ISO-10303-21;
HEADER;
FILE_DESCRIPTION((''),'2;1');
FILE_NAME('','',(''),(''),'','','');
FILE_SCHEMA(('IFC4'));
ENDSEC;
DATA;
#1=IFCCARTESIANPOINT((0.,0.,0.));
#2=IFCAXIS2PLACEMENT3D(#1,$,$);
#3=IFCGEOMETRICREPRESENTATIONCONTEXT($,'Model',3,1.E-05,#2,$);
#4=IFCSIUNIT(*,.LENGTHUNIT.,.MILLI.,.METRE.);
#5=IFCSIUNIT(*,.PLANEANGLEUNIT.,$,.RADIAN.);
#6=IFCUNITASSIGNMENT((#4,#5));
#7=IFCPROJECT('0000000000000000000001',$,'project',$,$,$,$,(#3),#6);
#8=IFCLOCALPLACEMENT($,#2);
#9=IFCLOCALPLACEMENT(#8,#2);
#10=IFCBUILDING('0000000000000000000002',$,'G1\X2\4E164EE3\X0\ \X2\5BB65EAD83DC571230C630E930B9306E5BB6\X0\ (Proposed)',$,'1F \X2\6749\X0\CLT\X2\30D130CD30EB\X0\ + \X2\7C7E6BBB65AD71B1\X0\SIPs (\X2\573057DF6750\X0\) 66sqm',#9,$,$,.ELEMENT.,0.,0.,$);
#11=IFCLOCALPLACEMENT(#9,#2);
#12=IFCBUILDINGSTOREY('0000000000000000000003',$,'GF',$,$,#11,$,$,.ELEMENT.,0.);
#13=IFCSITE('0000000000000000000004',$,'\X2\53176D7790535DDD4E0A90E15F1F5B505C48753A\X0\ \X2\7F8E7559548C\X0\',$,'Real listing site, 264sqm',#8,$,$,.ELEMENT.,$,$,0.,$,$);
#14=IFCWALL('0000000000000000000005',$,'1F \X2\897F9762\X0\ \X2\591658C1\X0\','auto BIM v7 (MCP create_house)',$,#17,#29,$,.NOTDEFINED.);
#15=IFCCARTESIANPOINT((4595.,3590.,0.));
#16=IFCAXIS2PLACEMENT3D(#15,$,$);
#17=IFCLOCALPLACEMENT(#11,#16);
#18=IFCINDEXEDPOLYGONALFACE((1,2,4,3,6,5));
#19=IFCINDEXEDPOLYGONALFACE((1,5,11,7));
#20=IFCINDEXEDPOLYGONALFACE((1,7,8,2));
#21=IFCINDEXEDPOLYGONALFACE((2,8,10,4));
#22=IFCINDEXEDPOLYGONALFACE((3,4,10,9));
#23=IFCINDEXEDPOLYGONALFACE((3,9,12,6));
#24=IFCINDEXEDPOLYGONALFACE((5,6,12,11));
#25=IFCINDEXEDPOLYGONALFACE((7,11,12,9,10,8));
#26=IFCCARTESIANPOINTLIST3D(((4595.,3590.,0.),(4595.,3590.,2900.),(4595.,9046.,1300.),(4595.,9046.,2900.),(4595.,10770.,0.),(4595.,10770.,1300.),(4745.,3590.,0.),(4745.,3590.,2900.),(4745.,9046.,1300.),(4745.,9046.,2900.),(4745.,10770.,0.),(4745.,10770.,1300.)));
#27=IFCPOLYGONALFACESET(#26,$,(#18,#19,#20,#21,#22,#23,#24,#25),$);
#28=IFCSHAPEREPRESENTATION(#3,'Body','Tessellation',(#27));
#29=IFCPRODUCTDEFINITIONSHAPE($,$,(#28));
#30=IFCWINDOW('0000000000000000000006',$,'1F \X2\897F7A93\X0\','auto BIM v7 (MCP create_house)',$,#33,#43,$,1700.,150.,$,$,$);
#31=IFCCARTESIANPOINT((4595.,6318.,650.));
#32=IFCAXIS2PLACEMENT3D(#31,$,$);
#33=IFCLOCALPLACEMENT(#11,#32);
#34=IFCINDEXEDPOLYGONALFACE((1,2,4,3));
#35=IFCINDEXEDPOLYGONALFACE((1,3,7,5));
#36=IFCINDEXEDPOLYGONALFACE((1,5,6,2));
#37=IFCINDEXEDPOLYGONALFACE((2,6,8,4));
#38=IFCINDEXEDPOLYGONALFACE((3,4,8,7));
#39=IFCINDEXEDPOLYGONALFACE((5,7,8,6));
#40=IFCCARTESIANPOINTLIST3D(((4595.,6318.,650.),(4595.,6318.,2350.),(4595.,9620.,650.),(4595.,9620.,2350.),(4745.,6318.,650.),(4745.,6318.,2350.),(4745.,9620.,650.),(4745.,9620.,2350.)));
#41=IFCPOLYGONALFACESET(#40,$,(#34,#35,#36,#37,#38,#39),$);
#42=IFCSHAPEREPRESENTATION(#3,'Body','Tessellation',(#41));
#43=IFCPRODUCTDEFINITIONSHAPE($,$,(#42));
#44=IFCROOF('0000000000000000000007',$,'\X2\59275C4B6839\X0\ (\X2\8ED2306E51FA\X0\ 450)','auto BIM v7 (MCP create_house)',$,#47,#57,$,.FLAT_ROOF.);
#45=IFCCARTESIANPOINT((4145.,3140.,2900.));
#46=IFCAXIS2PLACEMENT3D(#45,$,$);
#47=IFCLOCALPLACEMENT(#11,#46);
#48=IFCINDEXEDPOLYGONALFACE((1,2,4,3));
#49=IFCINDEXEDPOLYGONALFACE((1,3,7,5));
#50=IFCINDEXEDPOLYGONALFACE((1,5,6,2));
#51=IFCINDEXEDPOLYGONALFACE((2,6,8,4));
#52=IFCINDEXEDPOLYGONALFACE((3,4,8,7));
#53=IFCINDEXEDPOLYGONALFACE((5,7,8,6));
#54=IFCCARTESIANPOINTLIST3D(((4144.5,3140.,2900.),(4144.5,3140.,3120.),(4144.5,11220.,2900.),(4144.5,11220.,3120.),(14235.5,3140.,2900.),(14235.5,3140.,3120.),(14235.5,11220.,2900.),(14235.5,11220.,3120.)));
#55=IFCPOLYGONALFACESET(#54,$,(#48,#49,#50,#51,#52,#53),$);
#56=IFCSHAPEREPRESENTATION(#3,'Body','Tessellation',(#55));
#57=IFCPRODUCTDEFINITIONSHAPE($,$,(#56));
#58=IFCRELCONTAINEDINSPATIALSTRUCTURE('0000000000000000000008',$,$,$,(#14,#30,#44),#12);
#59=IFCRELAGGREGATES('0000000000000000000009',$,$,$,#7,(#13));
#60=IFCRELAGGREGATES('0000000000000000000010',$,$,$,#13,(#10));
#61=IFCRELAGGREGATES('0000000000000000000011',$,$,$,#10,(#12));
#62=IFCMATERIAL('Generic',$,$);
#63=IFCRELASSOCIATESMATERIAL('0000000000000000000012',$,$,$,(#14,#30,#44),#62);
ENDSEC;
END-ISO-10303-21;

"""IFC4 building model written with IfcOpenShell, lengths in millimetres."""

from ifc_helpers import new_model, si_unit, frame, frame_2d, origin, place, context, project, spatial, rectangle, extrude, material, element, fill, save


model = new_model("IFC4")

# Units and contexts
model_context = context("Model", 3, precision=1e-05, world=origin())
ifc_project = project(units=[si_unit("LENGTHUNIT", "METRE", prefix="MILLI"), si_unit("PLANEANGLEUNIT", "RADIAN")], contexts=[model_context])

# Site, building, storey
site_placement = place(None, origin())
site = spatial("IfcSite", under=ifc_project, at=site_placement, Name="北海道川上郡弟子屈町 美留和", ObjectType="Real listing site, 264sqm", CompositionType="ELEMENT", RefElevation=0.0)
building_placement = place(site_placement, origin())
building = spatial("IfcBuilding", under=site, at=building_placement, Name="G1世代 家庭菜園テラスの家 (Proposed)", ObjectType="1F 杉CLTパネル + 籾殻断熱SIPs (地域材) 66sqm", CompositionType="ELEMENT", ElevationOfRefHeight=0.0, ElevationOfTerrain=0.0)
storey_placement = place(building_placement, origin())
storey = spatial("IfcBuildingStorey", under=building, at=storey_placement, Name="GF", CompositionType="ELEMENT", Elevation=0.0)

# Shared definitions
ifc_material = material(Name="Generic")

# Wall, opening, window
wall_1_placement = place(storey_placement, frame((4595.0, 3590.0, 0.0)))
wall_1 = element("IfcWall", 1, at=wall_1_placement, inside=storey, material=ifc_material, Name="1F 西面 外壁", Description="auto BIM v7 (MCP create_house)", PredefinedType="NOTDEFINED", context=model_context, shape_type="SweptSolid", body=[
    extrude(rectangle(XDim=150.0, YDim=7180.0, at=frame_2d((75.0, 3590.0))), frame((4595.0, 3590.0, 0.0)), (0.0, 0.0, 1.0), 2900.0),
])
opening_1_placement = place(storey_placement, frame((4595.0, 6318.0, 650.0)))
opening_1 = element("IfcOpeningElement", 2, at=opening_1_placement, cuts=wall_1, PredefinedType="NOTDEFINED", context=model_context, shape_type="SweptSolid", body=[
    extrude(rectangle(XDim=150.0, YDim=3302.0, at=frame_2d((75.0, 1651.0))), frame((4595.0, 6318.0, 650.0)), (0.0, 0.0, 1.0), 1700.0),
])
window_1_placement = place(storey_placement, frame((4595.0, 6318.0, 650.0)))
window_1 = element("IfcWindow", 3, at=window_1_placement, inside=storey, material=ifc_material, Name="1F 西窓", Description="auto BIM v7 (MCP create_house)", OverallHeight=1700.0, OverallWidth=150.0, context=model_context, shape_type="SweptSolid", body=[
    extrude(rectangle(XDim=150.0, YDim=3302.0, at=frame_2d((75.0, 1651.0))), frame((4595.0, 6318.0, 650.0)), (0.0, 0.0, 1.0), 1700.0),
])
fill(opening_1, window_1)

# Roof
roof_placement = place(storey_placement, frame((4145.0, 3140.0, 2900.0)))
element("IfcRoof", 4, at=roof_placement, inside=storey, material=ifc_material, Name="大屋根 (軒の出 450)", Description="auto BIM v7 (MCP create_house)", PredefinedType="FLAT_ROOF", context=model_context, shape_type="SweptSolid", body=[
    extrude(rectangle(XDim=10091.0, YDim=8080.0, at=frame_2d((5045.0, 4040.0))), frame((4145.0, 3140.0, 2900.0)), (0.0, 0.0, 1.0), 220.0),
])

save(model, "model.ifc")
